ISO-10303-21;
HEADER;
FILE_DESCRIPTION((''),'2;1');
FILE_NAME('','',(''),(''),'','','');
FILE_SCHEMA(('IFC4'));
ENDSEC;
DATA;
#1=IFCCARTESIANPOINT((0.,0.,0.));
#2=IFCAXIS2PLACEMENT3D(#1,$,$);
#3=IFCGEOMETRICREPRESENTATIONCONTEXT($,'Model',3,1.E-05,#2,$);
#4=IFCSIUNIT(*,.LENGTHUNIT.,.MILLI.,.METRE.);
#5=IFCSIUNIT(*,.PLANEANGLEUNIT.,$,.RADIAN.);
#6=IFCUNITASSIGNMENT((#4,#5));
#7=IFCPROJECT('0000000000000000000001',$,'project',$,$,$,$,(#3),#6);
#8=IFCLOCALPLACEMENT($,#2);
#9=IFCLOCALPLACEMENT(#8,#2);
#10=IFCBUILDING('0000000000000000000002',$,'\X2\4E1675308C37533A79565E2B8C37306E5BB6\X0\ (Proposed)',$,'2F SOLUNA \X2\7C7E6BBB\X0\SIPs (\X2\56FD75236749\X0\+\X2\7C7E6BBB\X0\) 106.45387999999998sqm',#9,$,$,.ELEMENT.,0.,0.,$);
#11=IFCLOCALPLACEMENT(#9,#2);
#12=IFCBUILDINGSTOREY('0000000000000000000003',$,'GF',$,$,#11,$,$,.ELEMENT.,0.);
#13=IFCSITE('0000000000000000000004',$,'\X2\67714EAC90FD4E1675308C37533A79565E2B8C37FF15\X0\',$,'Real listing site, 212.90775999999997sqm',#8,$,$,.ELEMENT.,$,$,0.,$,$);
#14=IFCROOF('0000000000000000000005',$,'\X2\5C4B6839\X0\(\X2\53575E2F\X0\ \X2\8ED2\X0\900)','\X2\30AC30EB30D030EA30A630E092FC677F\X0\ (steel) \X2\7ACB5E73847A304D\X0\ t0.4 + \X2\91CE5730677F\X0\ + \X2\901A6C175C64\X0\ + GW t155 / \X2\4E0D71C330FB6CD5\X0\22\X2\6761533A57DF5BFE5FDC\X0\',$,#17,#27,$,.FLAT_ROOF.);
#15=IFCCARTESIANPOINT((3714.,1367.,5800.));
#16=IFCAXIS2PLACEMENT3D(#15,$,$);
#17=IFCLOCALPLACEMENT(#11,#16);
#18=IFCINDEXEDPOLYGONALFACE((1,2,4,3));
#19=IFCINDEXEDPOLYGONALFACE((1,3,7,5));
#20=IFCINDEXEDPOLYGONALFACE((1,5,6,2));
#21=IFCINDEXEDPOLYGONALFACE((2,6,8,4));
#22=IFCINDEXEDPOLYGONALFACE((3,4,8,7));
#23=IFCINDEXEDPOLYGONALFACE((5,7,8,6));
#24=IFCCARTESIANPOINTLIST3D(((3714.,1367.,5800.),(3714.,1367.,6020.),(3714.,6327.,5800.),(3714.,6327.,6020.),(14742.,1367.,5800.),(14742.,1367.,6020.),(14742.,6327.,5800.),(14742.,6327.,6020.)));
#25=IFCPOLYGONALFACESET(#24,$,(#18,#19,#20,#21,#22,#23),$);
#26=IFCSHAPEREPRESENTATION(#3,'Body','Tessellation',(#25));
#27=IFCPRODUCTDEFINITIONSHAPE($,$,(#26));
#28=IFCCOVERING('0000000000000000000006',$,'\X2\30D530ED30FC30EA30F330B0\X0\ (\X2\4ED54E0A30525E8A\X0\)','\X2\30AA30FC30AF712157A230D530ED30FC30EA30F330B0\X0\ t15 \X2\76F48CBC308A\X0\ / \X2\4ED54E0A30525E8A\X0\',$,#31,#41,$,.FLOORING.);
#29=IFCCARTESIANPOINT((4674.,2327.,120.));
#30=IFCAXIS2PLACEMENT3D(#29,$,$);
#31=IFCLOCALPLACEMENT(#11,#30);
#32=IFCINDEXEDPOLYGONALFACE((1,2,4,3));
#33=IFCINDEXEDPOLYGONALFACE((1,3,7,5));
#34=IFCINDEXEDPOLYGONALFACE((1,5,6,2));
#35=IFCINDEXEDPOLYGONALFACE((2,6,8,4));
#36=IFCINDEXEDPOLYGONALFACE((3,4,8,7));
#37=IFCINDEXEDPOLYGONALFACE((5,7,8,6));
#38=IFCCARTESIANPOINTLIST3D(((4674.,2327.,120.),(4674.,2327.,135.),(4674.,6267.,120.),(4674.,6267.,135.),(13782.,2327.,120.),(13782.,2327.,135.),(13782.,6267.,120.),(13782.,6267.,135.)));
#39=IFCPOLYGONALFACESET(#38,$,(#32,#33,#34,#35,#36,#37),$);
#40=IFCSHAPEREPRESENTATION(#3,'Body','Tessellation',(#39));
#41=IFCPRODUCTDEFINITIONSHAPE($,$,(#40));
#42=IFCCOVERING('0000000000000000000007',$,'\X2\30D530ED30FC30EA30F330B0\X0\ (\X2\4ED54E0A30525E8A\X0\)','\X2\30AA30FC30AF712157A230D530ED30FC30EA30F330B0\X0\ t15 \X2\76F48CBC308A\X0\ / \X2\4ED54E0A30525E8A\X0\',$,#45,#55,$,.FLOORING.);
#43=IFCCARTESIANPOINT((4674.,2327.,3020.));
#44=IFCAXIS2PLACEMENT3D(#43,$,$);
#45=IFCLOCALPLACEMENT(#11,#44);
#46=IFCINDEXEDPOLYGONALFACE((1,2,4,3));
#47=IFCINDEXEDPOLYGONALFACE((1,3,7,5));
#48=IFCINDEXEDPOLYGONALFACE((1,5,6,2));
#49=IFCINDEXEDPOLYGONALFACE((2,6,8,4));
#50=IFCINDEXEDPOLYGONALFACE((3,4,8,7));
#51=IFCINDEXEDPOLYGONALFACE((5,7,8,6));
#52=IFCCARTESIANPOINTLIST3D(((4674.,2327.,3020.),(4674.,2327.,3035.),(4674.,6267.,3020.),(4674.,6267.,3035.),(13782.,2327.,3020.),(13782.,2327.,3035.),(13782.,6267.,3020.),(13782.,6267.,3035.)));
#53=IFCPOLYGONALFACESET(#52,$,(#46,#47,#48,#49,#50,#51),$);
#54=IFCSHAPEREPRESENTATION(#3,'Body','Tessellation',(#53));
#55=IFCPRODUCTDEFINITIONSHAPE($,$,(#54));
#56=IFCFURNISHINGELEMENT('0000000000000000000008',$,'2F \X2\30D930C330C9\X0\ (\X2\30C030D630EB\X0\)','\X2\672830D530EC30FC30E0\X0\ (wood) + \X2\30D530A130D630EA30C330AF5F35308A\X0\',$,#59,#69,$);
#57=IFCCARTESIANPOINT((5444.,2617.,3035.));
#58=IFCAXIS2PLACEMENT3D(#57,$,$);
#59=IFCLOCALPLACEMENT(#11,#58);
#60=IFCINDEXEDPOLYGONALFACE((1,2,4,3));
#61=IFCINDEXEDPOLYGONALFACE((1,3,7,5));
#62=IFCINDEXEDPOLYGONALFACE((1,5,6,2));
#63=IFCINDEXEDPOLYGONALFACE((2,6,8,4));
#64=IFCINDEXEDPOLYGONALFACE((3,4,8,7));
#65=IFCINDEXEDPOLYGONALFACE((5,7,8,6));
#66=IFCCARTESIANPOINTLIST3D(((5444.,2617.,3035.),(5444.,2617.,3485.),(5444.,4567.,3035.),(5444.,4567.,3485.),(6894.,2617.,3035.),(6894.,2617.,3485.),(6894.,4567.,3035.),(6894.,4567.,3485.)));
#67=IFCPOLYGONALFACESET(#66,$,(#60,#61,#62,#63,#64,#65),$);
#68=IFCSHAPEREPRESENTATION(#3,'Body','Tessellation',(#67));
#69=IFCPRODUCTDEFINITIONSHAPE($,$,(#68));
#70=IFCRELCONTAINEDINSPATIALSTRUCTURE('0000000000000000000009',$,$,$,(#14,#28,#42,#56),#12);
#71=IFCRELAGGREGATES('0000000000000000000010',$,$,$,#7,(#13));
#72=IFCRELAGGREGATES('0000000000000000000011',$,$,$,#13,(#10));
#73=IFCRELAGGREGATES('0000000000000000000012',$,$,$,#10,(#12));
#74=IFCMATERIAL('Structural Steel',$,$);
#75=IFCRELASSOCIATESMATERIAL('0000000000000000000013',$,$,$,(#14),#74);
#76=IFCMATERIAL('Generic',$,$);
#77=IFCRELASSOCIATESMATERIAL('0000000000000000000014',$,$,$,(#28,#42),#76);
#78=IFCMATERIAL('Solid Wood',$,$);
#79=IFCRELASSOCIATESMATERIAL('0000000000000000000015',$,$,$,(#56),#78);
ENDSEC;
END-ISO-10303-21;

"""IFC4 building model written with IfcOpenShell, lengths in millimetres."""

from ifc_helpers import new_model, si_unit, frame, frame_2d, origin, place, context, project, spatial, rectangle, extrude, material, element, save


model = new_model("IFC4")

# Units and contexts
model_context = context("Model", 3, precision=1e-05, world=origin())
ifc_project = project(units=[si_unit("LENGTHUNIT", "METRE", prefix="MILLI"), si_unit("PLANEANGLEUNIT", "RADIAN")], contexts=[model_context])

# Site, building, storey
site_placement = place(None, origin())
site = spatial("IfcSite", under=ifc_project, at=site_placement, Name="東京都世田谷区祖師谷５", ObjectType="Real listing site, 212.90775999999997sqm", CompositionType="ELEMENT", RefElevation=0.0)
building_placement = place(site_placement, origin())
building = spatial("IfcBuilding", under=site, at=building_placement, Name="世田谷区祖師谷の家 (Proposed)", ObjectType="2F SOLUNA 籾殻SIPs (国産杉+籾殻) 106.45387999999998sqm", CompositionType="ELEMENT", ElevationOfRefHeight=0.0, ElevationOfTerrain=0.0)
storey_placement = place(building_placement, origin())
storey = spatial("IfcBuildingStorey", under=building, at=storey_placement, Name="GF", CompositionType="ELEMENT", Elevation=0.0)

# Shared definitions
ifc_material_1 = material(Name="Solid Wood")

# Roof
ifc_material_2 = material(Name="Structural Steel")
for number, where, name in (
    (1, (3714.0, 1367.0, 5800.0), "屋根(南帯 軒900)"),
):
    element("IfcRoof", number, at=place(storey_placement, frame(where)), inside=storey, material=ifc_material_2, Name=name, Description="ガルバリウム鋼板 (steel) 立平葺き t0.4 + 野地板 + 通気層 + GW t155 / 不燃・法22条区域対応", PredefinedType="FLAT_ROOF", context=model_context, shape_type="SweptSolid", body=[
        extrude(rectangle(XDim=11028.0, YDim=4960.0, at=frame_2d((5514.0, 2480.0))), frame((3714.0, 1367.0, 5800.0)), (0.0, 0.0, 1.0), 220.0),
    ])

# Coverings
ifc_material_3 = material(Name="Generic")
covering_1_placement = place(storey_placement, frame((4674.0, 2327.0, 120.0)))
element("IfcCovering", 2, at=covering_1_placement, inside=storey, material=ifc_material_3, Name="フローリング (仕上げ床)", Description="オーク無垢フローリング t15 直貼り / 仕上げ床", PredefinedType="FLOORING", context=model_context, shape_type="SweptSolid", body=[
    extrude(rectangle(XDim=9108.0, YDim=3940.0, at=frame_2d((4554.0, 1970.0))), frame((4674.0, 2327.0, 120.0)), (0.0, 0.0, 1.0), 15.0),
])
covering_2_placement = place(storey_placement, frame((4674.0, 2327.0, 3020.0)))
element("IfcCovering", 3, at=covering_2_placement, inside=storey, material=ifc_material_3, Name="フローリング (仕上げ床)", Description="オーク無垢フローリング t15 直貼り / 仕上げ床", PredefinedType="FLOORING", context=model_context, shape_type="SweptSolid", body=[
    extrude(rectangle(XDim=9108.0, YDim=3940.0, at=frame_2d((4554.0, 1970.0))), frame((4674.0, 2327.0, 3020.0)), (0.0, 0.0, 1.0), 15.0),
])

# Furnishing element
furnishing_placement = place(storey_placement, frame((5444.0, 2617.0, 3035.0)))
element("IfcFurnishingElement", 4, at=furnishing_placement, inside=storey, material=ifc_material_1, Name="2F ベッド (ダブル)", Description="木フレーム (wood) + ファブリック張り", context=model_context, shape_type="SweptSolid", body=[
    extrude(rectangle(XDim=1450.0, YDim=1950.0, at=frame_2d((725.0, 975.0))), frame((5444.0, 2617.0, 3035.0)), (0.0, 0.0, 1.0), 450.0),
])

save(model, "model.ifc")
